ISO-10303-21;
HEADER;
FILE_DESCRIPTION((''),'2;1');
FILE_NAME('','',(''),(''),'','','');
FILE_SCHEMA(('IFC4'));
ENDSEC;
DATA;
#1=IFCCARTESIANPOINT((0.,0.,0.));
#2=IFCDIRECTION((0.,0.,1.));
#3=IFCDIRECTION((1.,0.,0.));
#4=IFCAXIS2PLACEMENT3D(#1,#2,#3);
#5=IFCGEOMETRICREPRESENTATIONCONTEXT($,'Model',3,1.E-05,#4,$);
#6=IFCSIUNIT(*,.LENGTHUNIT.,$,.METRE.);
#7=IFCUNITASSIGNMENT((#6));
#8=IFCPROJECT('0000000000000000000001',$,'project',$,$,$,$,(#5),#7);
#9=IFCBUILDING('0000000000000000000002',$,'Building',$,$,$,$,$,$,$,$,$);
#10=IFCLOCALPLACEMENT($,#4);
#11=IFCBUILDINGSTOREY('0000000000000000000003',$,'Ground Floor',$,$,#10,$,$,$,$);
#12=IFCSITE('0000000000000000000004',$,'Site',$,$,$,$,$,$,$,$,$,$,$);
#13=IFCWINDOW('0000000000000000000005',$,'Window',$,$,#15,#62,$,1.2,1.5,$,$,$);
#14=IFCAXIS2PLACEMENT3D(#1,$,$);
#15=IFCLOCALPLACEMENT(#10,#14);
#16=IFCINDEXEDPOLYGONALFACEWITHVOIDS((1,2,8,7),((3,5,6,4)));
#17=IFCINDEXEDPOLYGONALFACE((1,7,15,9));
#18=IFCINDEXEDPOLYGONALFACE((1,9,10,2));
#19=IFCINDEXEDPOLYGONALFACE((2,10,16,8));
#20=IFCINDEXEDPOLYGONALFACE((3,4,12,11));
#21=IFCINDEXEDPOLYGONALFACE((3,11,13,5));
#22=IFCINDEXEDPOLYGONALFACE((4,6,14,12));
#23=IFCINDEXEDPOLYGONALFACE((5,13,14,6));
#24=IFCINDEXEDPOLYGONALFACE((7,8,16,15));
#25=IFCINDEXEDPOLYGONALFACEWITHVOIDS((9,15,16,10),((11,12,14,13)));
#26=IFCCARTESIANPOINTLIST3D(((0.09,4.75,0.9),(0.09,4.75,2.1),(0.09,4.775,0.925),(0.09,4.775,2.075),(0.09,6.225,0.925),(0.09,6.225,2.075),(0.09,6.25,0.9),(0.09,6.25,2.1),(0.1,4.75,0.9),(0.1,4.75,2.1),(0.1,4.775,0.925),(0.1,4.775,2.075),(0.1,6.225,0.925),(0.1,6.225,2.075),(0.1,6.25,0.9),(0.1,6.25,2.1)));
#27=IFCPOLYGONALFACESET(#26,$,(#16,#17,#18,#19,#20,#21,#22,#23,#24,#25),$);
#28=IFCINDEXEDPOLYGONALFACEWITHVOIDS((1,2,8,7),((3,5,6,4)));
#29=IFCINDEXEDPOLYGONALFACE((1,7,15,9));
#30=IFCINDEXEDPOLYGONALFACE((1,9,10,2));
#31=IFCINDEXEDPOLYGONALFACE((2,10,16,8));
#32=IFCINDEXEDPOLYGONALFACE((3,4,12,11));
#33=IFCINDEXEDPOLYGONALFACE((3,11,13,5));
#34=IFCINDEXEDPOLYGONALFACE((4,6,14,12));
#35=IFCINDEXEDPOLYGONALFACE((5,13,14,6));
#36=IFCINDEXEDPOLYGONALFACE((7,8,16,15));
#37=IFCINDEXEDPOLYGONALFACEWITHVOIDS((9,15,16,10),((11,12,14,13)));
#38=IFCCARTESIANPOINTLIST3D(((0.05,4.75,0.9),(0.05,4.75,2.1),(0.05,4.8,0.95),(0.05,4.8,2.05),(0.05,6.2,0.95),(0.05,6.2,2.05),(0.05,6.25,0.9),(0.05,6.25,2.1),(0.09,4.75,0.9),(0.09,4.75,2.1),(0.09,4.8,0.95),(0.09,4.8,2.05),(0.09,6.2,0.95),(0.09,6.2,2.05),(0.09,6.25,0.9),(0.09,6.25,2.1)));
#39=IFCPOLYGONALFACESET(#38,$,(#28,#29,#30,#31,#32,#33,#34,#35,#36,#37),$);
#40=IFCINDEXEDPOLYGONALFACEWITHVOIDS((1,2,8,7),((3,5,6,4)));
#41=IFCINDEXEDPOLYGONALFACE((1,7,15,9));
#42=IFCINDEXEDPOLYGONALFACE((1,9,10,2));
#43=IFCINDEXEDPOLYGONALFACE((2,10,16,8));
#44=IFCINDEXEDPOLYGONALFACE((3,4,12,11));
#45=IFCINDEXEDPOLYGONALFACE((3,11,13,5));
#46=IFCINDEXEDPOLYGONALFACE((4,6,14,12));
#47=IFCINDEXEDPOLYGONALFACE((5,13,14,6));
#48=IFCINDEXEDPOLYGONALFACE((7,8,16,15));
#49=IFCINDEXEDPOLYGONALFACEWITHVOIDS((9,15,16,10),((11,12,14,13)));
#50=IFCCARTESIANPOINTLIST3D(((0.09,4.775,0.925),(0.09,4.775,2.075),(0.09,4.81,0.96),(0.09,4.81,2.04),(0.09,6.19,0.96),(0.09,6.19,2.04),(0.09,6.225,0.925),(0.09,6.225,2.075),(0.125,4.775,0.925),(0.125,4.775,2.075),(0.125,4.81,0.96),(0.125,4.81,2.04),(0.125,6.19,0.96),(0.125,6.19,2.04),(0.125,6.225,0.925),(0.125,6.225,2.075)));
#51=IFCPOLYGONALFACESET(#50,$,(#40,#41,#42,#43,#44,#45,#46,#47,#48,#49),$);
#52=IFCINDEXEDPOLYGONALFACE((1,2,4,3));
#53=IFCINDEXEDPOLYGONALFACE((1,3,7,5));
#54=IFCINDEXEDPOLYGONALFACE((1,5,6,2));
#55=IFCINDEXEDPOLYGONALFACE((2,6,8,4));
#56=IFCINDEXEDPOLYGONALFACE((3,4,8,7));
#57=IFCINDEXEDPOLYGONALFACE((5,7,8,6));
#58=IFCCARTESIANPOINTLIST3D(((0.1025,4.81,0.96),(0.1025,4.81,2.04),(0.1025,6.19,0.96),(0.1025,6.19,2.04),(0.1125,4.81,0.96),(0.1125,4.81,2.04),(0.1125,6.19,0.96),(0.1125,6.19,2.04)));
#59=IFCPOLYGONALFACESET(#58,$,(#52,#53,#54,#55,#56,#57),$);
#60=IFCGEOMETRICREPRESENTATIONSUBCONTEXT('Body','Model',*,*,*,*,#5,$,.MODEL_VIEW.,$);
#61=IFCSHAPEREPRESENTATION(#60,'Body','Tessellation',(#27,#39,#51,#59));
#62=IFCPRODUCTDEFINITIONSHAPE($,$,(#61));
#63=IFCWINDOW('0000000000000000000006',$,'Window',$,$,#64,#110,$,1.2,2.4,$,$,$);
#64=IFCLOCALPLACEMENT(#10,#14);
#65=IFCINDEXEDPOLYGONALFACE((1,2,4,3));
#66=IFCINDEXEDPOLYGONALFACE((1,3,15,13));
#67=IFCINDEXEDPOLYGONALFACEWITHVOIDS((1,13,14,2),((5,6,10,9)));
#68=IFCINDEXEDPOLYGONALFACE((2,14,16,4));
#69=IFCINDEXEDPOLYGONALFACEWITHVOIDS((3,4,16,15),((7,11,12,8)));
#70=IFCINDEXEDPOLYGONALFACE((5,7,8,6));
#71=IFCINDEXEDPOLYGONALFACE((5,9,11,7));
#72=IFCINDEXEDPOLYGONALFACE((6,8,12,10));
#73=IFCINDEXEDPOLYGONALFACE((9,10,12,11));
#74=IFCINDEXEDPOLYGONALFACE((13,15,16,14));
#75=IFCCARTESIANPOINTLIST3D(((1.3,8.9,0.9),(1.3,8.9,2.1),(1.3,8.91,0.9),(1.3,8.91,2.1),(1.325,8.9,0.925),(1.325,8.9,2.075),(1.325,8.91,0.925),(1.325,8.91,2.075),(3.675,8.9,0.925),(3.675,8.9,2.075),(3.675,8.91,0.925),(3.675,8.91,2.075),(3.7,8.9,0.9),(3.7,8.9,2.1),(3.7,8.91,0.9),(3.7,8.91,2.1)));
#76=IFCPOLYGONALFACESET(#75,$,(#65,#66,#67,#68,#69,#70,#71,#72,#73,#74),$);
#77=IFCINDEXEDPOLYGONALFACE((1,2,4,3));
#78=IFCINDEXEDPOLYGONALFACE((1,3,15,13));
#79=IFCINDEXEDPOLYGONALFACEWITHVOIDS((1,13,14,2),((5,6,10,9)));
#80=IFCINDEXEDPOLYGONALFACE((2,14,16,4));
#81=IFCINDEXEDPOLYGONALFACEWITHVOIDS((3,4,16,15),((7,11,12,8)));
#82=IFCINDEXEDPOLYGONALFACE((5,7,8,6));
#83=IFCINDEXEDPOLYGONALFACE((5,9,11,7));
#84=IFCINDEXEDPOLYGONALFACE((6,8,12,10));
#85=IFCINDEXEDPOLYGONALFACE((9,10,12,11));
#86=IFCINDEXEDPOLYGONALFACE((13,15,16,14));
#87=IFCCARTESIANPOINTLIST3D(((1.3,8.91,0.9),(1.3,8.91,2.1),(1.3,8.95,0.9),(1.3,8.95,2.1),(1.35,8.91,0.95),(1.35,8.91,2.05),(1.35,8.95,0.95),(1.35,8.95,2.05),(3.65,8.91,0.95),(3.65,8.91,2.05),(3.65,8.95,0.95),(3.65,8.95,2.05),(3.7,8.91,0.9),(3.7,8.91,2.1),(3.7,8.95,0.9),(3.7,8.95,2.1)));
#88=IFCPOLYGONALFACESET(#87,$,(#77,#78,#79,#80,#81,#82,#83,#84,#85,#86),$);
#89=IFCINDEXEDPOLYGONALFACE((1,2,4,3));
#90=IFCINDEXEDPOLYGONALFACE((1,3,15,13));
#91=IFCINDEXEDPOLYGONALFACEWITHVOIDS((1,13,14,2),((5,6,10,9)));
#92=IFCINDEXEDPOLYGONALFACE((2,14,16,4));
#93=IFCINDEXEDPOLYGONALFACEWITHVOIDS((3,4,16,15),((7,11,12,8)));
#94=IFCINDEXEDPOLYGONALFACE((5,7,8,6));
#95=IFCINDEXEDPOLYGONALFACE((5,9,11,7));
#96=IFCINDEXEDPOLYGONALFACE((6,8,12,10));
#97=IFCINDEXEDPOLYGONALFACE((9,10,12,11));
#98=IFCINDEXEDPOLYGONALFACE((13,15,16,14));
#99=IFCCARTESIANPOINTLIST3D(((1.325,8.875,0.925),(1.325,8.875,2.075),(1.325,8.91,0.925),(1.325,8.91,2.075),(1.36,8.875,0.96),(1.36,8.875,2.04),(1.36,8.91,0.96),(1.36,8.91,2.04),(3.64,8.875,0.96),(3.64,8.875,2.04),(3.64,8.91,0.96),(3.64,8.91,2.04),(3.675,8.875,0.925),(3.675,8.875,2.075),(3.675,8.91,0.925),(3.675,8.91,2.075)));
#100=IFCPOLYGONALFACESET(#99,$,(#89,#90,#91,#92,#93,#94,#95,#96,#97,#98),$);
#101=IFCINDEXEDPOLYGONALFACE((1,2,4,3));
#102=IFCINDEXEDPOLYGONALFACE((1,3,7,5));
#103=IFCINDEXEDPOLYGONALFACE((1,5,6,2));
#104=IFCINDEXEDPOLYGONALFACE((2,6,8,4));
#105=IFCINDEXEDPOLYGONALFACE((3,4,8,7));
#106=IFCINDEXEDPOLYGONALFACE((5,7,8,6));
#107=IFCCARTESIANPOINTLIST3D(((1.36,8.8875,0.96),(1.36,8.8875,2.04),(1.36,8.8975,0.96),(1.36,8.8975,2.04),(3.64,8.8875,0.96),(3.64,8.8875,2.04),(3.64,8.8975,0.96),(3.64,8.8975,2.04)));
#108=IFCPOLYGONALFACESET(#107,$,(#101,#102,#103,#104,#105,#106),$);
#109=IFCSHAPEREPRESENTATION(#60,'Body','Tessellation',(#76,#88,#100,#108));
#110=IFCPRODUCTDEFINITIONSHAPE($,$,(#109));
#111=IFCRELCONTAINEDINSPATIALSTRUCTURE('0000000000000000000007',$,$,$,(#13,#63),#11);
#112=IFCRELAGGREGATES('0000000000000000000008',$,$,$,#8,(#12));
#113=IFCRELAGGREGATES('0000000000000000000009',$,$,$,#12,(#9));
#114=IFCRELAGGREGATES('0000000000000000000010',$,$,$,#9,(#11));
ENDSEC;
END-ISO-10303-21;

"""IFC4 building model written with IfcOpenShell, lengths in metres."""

from ifc_helpers import new_model, si_unit, frame, origin_with_axes, place, context, subcontext, project, spatial, line, indexed_curve, outline, extrude, element, save


model = new_model("IFC4")

# Units and contexts
model_context = context("Model", 3, precision=1e-05, world=origin_with_axes())
body_context = subcontext(model_context, "Body", "Model", "MODEL_VIEW")
ifc_project = project(units=[si_unit("LENGTHUNIT", "METRE")], contexts=[model_context])

# Site, building, storey
site = spatial("IfcSite", under=ifc_project, Name="Site")
building = spatial("IfcBuilding", under=site, Name="Building")
storey_placement = place(None, origin_with_axes())
storey = spatial("IfcBuildingStorey", under=building, at=storey_placement, Name="Ground Floor")

# Windows
for number, where, z_axis, x_axis, name in (
    (1, (0.0, 6.25, 0.9), (0.0, 0.0, 1.0), (0.0, -1.0, 0.0), "Window"),
):
    element("IfcWindow", number, at=place(storey_placement, frame(where, z_axis=z_axis, x_axis=x_axis)), inside=storey, Name=name, OverallHeight=1.2, OverallWidth=1.5, context=body_context, shape_type="SweptSolid", body=[
        extrude(outline(indexed_curve([(0.0, 0.0), (1.5, 0.0), (1.5, 1.2), (0.0, 1.2)], segments=[line(1, 2, 3, 4, 1)]), holes=[indexed_curve([(0.025, 0.025), (1.475, 0.025), (1.475, 1.175), (0.025, 1.175)], segments=[line(1, 2, 3, 4, 1)])]), frame((0.0, 0.09, 0.0), z_axis=(0.0, -1.0, 0.0), x_axis=(1.0, 0.0, 0.0)), (0.0, 0.0, -1.0), 0.01),
        extrude(outline(indexed_curve([(0.0, 0.0), (1.5, 0.0), (1.5, 1.2), (0.0, 1.2)], segments=[line(1, 2, 3, 4, 1)]), holes=[indexed_curve([(0.05, 0.05), (1.45, 0.05), (1.45, 1.15), (0.05, 1.15)], segments=[line(1, 2, 3, 4, 1)])]), frame((0.0, 0.05, 0.0), z_axis=(0.0, -1.0, 0.0), x_axis=(1.0, 0.0, 0.0)), (0.0, 0.0, -1.0), 0.04),
        extrude(outline(indexed_curve([(0.0, 0.0), (1.45, 0.0), (1.45, 1.15), (0.0, 1.15)], segments=[line(1, 2, 3, 4, 1)]), holes=[indexed_curve([(0.035, 0.035), (1.415, 0.035), (1.415, 1.115), (0.035, 1.115)], segments=[line(1, 2, 3, 4, 1)])]), frame((0.025, 0.09, 0.025), z_axis=(0.0, -1.0, 0.0), x_axis=(1.0, 0.0, 0.0)), (0.0, 0.0, -1.0), 0.035),
        extrude(outline(indexed_curve([(0.035, 0.035), (1.415, 0.035), (1.415, 1.115), (0.035, 1.115)], segments=[line(1, 2, 3, 4, 1)])), frame((0.025, 0.1025, 0.025), z_axis=(0.0, -1.0, 0.0), x_axis=(1.0, 0.0, 0.0)), (0.0, 0.0, -1.0), 0.01),
    ])
window_1_placement = place(storey_placement, frame((3.7, 9.0, 0.9), z_axis=(0.0, 0.0, 1.0), x_axis=(-1.0, 0.0, 0.0)))
element("IfcWindow", 2, at=window_1_placement, inside=storey, Name="Window", OverallHeight=1.2, OverallWidth=2.4, context=body_context, shape_type="SweptSolid", body=[
    extrude(outline(indexed_curve([(0.0, 0.0), (2.4, 0.0), (2.4, 1.2), (0.0, 1.2)], segments=[line(1, 2, 3, 4, 1)]), holes=[indexed_curve([(0.025, 0.025), (2.375, 0.025), (2.375, 1.175), (0.025, 1.175)], segments=[line(1, 2, 3, 4, 1)])]), frame((0.0, 0.09, 0.0), z_axis=(0.0, -1.0, 0.0), x_axis=(1.0, 0.0, 0.0)), (0.0, 0.0, -1.0), 0.01),
    extrude(outline(indexed_curve([(0.0, 0.0), (2.4, 0.0), (2.4, 1.2), (0.0, 1.2)], segments=[line(1, 2, 3, 4, 1)]), holes=[indexed_curve([(0.05, 0.05), (2.35, 0.05), (2.35, 1.15), (0.05, 1.15)], segments=[line(1, 2, 3, 4, 1)])]), frame((0.0, 0.05, 0.0), z_axis=(0.0, -1.0, 0.0), x_axis=(1.0, 0.0, 0.0)), (0.0, 0.0, -1.0), 0.04),
    extrude(outline(indexed_curve([(0.0, 0.0), (2.35, 0.0), (2.35, 1.15), (0.0, 1.15)], segments=[line(1, 2, 3, 4, 1)]), holes=[indexed_curve([(0.035, 0.035), (2.315, 0.035), (2.315, 1.115), (0.035, 1.115)], segments=[line(1, 2, 3, 4, 1)])]), frame((0.025, 0.09, 0.025), z_axis=(0.0, -1.0, 0.0), x_axis=(1.0, 0.0, 0.0)), (0.0, 0.0, -1.0), 0.035),
    extrude(outline(indexed_curve([(0.035, 0.035), (2.315, 0.035), (2.315, 1.115), (0.035, 1.115)], segments=[line(1, 2, 3, 4, 1)])), frame((0.025, 0.1025, 0.025), z_axis=(0.0, -1.0, 0.0), x_axis=(1.0, 0.0, 0.0)), (0.0, 0.0, -1.0), 0.01),
])

save(model, "model.ifc")
